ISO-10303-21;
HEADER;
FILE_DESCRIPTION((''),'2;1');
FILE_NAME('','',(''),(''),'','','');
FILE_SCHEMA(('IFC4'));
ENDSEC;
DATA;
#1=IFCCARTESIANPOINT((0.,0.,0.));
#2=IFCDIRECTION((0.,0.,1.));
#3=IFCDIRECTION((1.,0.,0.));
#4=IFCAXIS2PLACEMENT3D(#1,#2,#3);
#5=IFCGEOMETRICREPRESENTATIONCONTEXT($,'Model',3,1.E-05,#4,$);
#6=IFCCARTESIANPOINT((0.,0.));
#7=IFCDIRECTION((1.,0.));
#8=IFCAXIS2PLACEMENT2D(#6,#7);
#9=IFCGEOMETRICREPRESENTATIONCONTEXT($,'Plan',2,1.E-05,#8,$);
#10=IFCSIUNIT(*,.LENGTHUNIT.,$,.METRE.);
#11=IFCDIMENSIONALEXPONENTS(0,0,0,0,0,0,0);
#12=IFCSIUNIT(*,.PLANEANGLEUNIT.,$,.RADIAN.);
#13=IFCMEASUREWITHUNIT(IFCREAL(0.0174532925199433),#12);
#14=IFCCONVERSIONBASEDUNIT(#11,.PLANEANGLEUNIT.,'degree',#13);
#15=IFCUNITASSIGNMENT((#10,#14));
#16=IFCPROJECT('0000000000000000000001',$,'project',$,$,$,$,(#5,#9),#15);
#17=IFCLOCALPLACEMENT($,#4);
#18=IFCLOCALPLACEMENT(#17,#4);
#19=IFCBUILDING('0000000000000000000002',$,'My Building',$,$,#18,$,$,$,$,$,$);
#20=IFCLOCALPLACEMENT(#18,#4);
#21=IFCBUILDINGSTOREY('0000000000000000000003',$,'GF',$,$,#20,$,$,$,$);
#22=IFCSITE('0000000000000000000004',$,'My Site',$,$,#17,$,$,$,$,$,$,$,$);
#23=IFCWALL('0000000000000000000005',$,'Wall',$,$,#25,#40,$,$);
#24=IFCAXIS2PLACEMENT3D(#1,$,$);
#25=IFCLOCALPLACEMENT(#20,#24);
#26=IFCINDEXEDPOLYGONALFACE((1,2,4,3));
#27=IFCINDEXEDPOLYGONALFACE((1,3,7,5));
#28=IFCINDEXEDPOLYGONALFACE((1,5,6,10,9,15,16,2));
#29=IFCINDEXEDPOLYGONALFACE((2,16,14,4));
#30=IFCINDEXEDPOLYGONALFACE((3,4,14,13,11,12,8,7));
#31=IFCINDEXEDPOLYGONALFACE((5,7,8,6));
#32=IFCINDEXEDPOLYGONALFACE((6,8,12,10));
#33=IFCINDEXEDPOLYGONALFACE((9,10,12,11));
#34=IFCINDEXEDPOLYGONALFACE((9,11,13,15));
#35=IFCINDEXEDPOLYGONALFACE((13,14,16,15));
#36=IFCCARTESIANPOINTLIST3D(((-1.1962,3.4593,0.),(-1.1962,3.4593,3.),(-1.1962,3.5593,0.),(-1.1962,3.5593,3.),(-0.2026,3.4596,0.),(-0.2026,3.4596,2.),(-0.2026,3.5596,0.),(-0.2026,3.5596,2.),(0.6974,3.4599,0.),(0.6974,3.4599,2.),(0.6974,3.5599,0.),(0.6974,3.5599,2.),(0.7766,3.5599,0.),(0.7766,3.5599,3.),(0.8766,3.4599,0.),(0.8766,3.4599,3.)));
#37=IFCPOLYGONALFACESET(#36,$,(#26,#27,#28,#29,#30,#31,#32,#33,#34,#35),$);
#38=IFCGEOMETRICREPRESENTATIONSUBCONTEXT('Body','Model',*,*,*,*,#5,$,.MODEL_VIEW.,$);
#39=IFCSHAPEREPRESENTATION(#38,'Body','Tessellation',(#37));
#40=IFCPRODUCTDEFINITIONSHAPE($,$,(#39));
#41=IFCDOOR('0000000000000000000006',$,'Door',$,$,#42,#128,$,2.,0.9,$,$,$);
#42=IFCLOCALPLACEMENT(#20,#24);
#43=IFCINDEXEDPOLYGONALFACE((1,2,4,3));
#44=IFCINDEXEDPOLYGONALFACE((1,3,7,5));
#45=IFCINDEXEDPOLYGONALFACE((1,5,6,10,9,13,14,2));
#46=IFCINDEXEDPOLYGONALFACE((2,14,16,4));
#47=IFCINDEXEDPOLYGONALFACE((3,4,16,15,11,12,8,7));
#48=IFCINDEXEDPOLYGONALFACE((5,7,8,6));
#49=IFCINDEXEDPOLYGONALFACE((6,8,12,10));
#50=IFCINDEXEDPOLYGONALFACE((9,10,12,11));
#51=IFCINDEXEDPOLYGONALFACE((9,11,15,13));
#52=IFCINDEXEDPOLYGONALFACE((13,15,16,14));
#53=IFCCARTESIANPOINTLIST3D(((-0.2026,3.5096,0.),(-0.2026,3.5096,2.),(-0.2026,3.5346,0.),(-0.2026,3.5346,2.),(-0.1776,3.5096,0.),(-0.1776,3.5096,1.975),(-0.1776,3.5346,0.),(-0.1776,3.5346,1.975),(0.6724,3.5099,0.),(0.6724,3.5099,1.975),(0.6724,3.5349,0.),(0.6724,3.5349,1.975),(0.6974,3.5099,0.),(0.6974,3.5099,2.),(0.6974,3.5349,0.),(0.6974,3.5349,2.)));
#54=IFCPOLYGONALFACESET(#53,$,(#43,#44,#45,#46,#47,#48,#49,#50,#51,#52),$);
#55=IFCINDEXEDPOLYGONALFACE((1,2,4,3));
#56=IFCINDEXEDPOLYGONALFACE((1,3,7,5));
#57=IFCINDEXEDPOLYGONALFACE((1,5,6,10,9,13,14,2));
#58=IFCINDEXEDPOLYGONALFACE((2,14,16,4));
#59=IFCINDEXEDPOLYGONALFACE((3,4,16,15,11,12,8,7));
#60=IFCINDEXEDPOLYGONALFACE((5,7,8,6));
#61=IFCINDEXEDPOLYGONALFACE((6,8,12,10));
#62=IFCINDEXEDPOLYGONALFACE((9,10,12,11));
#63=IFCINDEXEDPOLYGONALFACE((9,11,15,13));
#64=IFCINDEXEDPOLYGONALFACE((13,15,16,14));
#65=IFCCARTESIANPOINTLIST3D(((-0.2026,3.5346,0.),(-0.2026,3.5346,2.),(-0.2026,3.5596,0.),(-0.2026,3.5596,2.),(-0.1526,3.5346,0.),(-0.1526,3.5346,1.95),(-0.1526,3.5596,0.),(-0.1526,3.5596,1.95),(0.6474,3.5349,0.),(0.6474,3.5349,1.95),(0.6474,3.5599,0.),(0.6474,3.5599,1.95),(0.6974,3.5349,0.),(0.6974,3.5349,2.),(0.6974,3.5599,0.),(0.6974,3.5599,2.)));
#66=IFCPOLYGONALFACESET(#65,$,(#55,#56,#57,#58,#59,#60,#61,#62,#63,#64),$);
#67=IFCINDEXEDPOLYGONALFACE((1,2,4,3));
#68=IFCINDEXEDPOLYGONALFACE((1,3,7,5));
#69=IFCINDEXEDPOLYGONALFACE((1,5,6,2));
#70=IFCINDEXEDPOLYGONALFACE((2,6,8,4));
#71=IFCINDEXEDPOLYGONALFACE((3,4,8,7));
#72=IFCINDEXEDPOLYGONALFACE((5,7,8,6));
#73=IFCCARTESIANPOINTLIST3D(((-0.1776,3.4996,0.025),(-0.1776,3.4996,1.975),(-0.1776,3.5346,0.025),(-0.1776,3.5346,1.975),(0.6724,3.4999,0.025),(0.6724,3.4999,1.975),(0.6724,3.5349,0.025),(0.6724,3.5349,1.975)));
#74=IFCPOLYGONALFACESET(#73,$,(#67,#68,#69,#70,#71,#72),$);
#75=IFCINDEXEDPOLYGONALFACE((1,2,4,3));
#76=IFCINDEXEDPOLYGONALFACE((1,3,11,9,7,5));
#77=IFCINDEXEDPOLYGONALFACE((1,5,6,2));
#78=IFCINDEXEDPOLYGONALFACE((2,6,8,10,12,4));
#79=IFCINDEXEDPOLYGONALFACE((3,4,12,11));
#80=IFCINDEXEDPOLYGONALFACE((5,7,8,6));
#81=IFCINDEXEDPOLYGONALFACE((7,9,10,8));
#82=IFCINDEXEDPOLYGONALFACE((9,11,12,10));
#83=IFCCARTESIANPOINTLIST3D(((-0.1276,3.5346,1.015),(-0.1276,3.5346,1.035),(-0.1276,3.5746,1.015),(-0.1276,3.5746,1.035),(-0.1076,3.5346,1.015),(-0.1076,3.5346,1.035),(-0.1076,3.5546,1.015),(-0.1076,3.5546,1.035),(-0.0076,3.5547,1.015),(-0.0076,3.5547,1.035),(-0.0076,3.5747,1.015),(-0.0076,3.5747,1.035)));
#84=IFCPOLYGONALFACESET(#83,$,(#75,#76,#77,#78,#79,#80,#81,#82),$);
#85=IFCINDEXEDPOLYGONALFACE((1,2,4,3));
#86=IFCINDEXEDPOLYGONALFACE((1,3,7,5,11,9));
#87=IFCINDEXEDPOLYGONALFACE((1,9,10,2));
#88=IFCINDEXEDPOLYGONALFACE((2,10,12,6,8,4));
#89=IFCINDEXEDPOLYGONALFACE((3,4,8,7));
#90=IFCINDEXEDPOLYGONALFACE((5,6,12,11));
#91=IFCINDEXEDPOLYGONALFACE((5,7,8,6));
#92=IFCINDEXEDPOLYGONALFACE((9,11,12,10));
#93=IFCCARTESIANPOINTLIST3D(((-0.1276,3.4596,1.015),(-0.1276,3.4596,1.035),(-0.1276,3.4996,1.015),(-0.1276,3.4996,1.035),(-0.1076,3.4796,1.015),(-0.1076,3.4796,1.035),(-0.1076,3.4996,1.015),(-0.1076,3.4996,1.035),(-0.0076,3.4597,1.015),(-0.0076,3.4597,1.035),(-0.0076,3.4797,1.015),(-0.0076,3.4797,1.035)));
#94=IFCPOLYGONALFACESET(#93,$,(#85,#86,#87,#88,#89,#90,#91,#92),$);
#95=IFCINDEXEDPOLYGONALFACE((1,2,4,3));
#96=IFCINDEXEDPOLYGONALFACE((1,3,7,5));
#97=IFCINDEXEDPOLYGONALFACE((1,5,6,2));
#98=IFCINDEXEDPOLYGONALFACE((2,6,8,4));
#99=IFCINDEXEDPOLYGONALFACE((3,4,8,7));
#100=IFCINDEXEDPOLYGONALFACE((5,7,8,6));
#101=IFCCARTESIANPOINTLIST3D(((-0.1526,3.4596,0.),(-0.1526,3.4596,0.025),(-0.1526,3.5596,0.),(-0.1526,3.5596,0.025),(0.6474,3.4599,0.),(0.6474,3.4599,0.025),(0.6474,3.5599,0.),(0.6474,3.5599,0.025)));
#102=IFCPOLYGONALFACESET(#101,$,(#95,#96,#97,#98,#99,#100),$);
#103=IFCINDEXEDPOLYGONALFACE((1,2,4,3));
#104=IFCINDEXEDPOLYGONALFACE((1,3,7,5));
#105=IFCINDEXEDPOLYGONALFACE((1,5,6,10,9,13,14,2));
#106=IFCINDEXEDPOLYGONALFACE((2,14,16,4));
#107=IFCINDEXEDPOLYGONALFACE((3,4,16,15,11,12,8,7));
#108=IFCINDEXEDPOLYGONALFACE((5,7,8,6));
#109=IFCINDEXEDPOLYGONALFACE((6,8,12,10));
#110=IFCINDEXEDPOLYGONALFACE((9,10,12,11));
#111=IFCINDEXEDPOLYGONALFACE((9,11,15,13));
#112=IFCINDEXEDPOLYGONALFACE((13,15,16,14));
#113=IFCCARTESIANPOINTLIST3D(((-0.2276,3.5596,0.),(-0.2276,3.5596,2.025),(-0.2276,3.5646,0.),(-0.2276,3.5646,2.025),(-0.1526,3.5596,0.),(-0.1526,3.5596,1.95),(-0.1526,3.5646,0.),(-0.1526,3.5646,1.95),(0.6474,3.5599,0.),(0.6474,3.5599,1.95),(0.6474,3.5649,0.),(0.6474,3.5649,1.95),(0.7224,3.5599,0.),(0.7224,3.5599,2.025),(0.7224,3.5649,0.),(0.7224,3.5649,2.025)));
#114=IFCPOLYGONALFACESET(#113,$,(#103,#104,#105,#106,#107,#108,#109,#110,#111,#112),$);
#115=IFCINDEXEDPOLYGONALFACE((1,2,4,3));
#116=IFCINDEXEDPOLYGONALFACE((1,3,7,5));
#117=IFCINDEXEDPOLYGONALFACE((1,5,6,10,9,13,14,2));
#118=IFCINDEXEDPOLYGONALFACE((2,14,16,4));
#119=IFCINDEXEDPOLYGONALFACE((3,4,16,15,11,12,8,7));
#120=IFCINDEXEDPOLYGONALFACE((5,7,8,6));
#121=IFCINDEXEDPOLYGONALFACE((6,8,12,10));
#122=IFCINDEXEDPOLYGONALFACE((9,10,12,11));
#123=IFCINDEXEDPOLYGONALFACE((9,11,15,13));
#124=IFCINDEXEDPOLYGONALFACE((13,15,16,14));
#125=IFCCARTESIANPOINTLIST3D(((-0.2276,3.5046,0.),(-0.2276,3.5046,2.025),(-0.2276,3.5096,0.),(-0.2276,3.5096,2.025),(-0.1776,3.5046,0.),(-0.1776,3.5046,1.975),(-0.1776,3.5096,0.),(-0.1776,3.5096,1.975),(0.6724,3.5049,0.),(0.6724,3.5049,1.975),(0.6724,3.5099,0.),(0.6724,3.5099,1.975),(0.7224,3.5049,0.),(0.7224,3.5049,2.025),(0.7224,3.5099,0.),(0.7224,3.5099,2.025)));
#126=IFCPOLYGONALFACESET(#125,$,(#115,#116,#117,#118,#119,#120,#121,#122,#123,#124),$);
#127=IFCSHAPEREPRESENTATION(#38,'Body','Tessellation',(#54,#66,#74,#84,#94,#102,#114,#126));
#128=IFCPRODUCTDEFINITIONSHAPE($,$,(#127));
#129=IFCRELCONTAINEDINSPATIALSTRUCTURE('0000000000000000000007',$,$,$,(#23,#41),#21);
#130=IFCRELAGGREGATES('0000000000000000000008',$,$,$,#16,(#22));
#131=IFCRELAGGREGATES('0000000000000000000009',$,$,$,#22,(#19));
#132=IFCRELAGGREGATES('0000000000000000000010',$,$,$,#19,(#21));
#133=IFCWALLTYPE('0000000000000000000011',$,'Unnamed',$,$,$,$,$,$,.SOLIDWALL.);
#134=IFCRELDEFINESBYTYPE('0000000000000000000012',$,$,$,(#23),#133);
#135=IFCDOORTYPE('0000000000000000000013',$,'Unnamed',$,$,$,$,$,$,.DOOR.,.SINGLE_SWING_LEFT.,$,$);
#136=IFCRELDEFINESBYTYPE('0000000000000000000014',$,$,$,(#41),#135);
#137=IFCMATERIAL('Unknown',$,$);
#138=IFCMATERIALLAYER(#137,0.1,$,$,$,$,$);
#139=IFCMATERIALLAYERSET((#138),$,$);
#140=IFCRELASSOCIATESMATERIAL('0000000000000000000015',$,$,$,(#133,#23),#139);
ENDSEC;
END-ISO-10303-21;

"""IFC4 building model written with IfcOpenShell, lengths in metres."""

from ifc_helpers import new_model, entity, si_unit, converted_unit, frame, origin_with_axes, origin_2d_with_axis, place, context, subcontext, project, spatial, line, indexed_curve, outline, extrude, shape, source, transform, mapped, material, layer, layer_set, layer_usage, type_object, type_shapes, element, fill, save


model = new_model("IFC4")

# Units and contexts
model_context = context("Model", 3, precision=1e-05, world=origin_with_axes())
plan_context = context("Plan", 2, precision=1e-05, world=origin_2d_with_axis())
body_context_1 = subcontext(model_context, "Body", "Model", "MODEL_VIEW")
body_context_2 = subcontext(plan_context, "Body", "Plan", "PLAN_VIEW")
ifc_project = project(units=[si_unit("LENGTHUNIT", "METRE"), converted_unit("PLANEANGLEUNIT", "degree", entity("IfcReal", 0.0174532925199433), si_unit("PLANEANGLEUNIT", "RADIAN"), dimensions=[0, 0, 0, 0, 0, 0, 0])], contexts=[model_context, plan_context])

# Site, building, storey
site_placement = place(None, origin_with_axes())
site = spatial("IfcSite", under=ifc_project, at=site_placement, Name="My Site")
building_placement = place(site_placement, origin_with_axes())
building = spatial("IfcBuilding", under=site, at=building_placement, Name="My Building")
storey_placement = place(building_placement, origin_with_axes())
storey = spatial("IfcBuildingStorey", under=building, at=storey_placement, Name="GF")

# Shared definitions
ifc_material = material(Name="Unknown")

# Shared definitions
ifc_layer_1 = layer(ifc_material, 0.1)
ifc_layer_set_1 = layer_set([ifc_layer_1])
wall_type = type_object("IfcWallType", Name="Unnamed", PredefinedType="SOLIDWALL", material=ifc_layer_set_1)
shared_shape_1 = source(origin_with_axes(), body_context_1, "Body", "SweptSolid", [
    extrude(outline(indexed_curve([(0.0, 0.0), (0.9, 0.0), (0.9, 2.0), (0.0, 2.0)], segments=[line(1, 2, 3, 4, 1)])), frame((0.0, -0.6, 0.0), z_axis=(0.0, -1.0, 0.0), x_axis=(1.0, 0.0, 0.0)), (0.0, 0.0, -1.0), 1.2),
])
door_type = type_object("IfcDoorType", Name="Unnamed", OperationType="SINGLE_SWING_LEFT", PredefinedType="DOOR")
shared_shape_2 = source(origin_with_axes(), body_context_1, "Body", "SweptSolid", [
    extrude(outline(indexed_curve([(0.0, 0.0), (0.0, 2.0), (0.9, 2.0), (0.9, 0.0), (0.875, 0.0), (0.875, 1.975), (0.025, 1.975), (0.025, 0.0)], segments=[line(1, 2, 3, 4, 5, 6, 7, 8, 1)])), frame((0.0, 0.025, 0.0), z_axis=(0.0, -1.0, 0.0), x_axis=(1.0, 0.0, 0.0)), (0.0, 0.0, -1.0), 0.025),
    extrude(outline(indexed_curve([(0.0, 0.0), (0.0, 2.0), (0.9, 2.0), (0.9, 0.0), (0.85, 0.0), (0.85, 1.95), (0.05, 1.95), (0.05, 0.0)], segments=[line(1, 2, 3, 4, 5, 6, 7, 8, 1)])), frame((0.0, 0.0, 0.0), z_axis=(0.0, -1.0, 0.0), x_axis=(1.0, 0.0, 0.0)), (0.0, 0.0, -1.0), 0.025),
    extrude(outline(indexed_curve([(0.0, 0.0), (0.85, 0.0), (0.85, 0.035), (0.0, 0.035)], segments=[line(1, 2, 3, 4, 1)])), frame((0.025, 0.025, 0.025), z_axis=(0.0, 0.0, 1.0), x_axis=(1.0, 0.0, 0.0)), (0.0, 0.0, 1.0), 1.95),
    extrude(outline(indexed_curve([(0.0, 0.0), (0.0, -0.04), (-0.12, -0.04), (-0.12, -0.02), (-0.02, -0.02), (-0.02, 0.0)], segments=[line(1, 2, 3, 4, 5, 6, 1)])), frame((0.825, 0.025, 1.015), z_axis=(0.0, 0.0, 1.0), x_axis=(1.0, 0.0, 0.0)), (0.0, 0.0, 1.0), 0.02),
    extrude(outline(indexed_curve([(0.0, 0.0), (0.0, 0.04), (-0.12, 0.04), (-0.12, 0.02), (-0.02, 0.02), (-0.02, 0.0)], segments=[line(1, 2, 3, 4, 5, 6, 1)])), frame((0.825, 0.06, 1.015), z_axis=(0.0, 0.0, 1.0), x_axis=(1.0, 0.0, 0.0)), (0.0, 0.0, 1.0), 0.02),
    extrude(outline(indexed_curve([(0.0, 0.0), (0.8, 0.0), (0.8, 0.1), (0.0, 0.1)], segments=[line(1, 2, 3, 4, 1)])), frame((0.05, 0.0, 0.0), z_axis=(0.0, 0.0, 1.0), x_axis=(1.0, 0.0, 0.0)), (0.0, 0.0, 1.0), 0.025),
    extrude(outline(indexed_curve([(0.0, 0.0), (0.0, 2.025), (0.95, 2.025), (0.95, 0.0), (0.875, 0.0), (0.875, 1.95), (0.075, 1.95), (0.075, 0.0)], segments=[line(1, 2, 3, 4, 5, 6, 7, 8, 1)])), frame((-0.025, -0.005, 0.0), z_axis=(0.0, -1.0, 0.0), x_axis=(1.0, 0.0, 0.0)), (0.0, 0.0, -1.0), 0.005),
    extrude(outline(indexed_curve([(0.0, 0.0), (0.0, 2.025), (0.95, 2.025), (0.95, 0.0), (0.9, 0.0), (0.9, 1.975), (0.05, 1.975), (0.05, 0.0)], segments=[line(1, 2, 3, 4, 5, 6, 7, 8, 1)])), frame((-0.025, 0.05, 0.0), z_axis=(0.0, -1.0, 0.0), x_axis=(1.0, 0.0, 0.0)), (0.0, 0.0, -1.0), 0.005),
])
shared_shape_3 = source(origin_with_axes(), body_context_2, "Body", "Curve2D", [
    entity("IfcIndexedPolyCurve", entity("IfcCartesianPointList2D", [[0.0, 0.0], [0.0, 0.05], [0.025, 0.05], [0.025, 0.025], [0.05, 0.025], [0.05, 0.0]]), [entity("IfcLineIndex", [1, 2, 3, 4, 5, 6, 1])]),
    entity("IfcIndexedPolyCurve", entity("IfcCartesianPointList2D", [[0.9, 0.0], [0.9, 0.05], [0.875, 0.05], [0.875, 0.025], [0.85, 0.025], [0.85, 0.0]]), [entity("IfcLineIndex", [1, 2, 3, 4, 5, 6, 1])]),
    entity("IfcTrimmedCurve", entity("IfcEllipse", entity("IfcAxis2Placement2D", entity("IfcCartesianPoint", [0.06, 0.05]), entity("IfcDirection", [1.0, 0.0])), 0.815, 0.85), [entity("IfcCartesianPoint", [0.875, 0.05])], [entity("IfcCartesianPoint", [0.06, 0.9])], True, "CARTESIAN"),
    entity("IfcIndexedPolyCurve", entity("IfcCartesianPointList2D", [[0.025, 0.05], [0.06, 0.05], [0.06, 0.9], [0.025, 0.9]]), [entity("IfcLineIndex", [1, 2, 3, 4, 1])]),
])
type_shapes(door_type, [shared_shape_2, shared_shape_3])

# Wall, opening, door
ifc_layer_usage_1 = layer_usage(ifc_layer_set_1, "AXIS2", "POSITIVE", 0.0)
wall_1_placement = place(storey_placement, frame((0.7766, 3.5599, 0.0), z_axis=(0.0, 0.0, 1.0), x_axis=(-1.0, -0.000309, 0.0)))
wall_1 = element("IfcWall", 1, at=wall_1_placement, inside=storey, type_object=wall_type, material=ifc_layer_usage_1, Name="Wall", context=body_context_1, shape_type="SweptSolid", body=[
    extrude(outline(indexed_curve([(0.0, 0.0), (-0.1, 0.1), (1.9728, 0.1), (1.9728, 0.0)], segments=[line(1, 2, 3, 4, 1)])), origin_with_axes(), (0.0, 0.0, 1.0), 3.0),
])
opening_1_placement = place(wall_1_placement, frame((0.0792, 0.0, 0.0), z_axis=(0.0, 0.0, 1.0), x_axis=(1.0, 0.0, 0.0)))
opening_1 = element("IfcOpeningElement", 2, at=opening_1_placement, cuts=wall_1, PredefinedType="OPENING", context=body_context_1, shape_type="MappedRepresentation", body=[
    mapped(shared_shape_1, transform((0.0, 0.0, 0.0), x_axis=(1.0, 0.0, 0.0), y_axis=(0.0, 1.0, 0.0), z_axis=(0.0, 0.0, 1.0), scale=1.0)),
])
door_1_placement = place(opening_1_placement, frame((0.0, 0.0, 0.0), z_axis=(0.0, 0.0, 1.0), x_axis=(1.0, 0.0, 0.0)))
door_1 = element("IfcDoor", 3, at=door_1_placement, inside=storey, type_object=door_type, Name="Door", OverallHeight=2.0, OverallWidth=0.9, shapes=[
    shape(body_context_1, "Body", "MappedRepresentation", [mapped(shared_shape_2, transform((0.0, 0.0, 0.0), x_axis=(1.0, 0.0, 0.0), y_axis=(0.0, 1.0, 0.0), z_axis=(0.0, 0.0, 1.0), scale=1.0))]),
    shape(body_context_2, "Body", "MappedRepresentation", [mapped(shared_shape_3, transform((0.0, 0.0, 0.0), x_axis=(1.0, 0.0, 0.0), y_axis=(0.0, 1.0, 0.0), z_axis=(0.0, 0.0, 1.0), scale=1.0))]),
])
fill(opening_1, door_1)

save(model, "model.ifc")
